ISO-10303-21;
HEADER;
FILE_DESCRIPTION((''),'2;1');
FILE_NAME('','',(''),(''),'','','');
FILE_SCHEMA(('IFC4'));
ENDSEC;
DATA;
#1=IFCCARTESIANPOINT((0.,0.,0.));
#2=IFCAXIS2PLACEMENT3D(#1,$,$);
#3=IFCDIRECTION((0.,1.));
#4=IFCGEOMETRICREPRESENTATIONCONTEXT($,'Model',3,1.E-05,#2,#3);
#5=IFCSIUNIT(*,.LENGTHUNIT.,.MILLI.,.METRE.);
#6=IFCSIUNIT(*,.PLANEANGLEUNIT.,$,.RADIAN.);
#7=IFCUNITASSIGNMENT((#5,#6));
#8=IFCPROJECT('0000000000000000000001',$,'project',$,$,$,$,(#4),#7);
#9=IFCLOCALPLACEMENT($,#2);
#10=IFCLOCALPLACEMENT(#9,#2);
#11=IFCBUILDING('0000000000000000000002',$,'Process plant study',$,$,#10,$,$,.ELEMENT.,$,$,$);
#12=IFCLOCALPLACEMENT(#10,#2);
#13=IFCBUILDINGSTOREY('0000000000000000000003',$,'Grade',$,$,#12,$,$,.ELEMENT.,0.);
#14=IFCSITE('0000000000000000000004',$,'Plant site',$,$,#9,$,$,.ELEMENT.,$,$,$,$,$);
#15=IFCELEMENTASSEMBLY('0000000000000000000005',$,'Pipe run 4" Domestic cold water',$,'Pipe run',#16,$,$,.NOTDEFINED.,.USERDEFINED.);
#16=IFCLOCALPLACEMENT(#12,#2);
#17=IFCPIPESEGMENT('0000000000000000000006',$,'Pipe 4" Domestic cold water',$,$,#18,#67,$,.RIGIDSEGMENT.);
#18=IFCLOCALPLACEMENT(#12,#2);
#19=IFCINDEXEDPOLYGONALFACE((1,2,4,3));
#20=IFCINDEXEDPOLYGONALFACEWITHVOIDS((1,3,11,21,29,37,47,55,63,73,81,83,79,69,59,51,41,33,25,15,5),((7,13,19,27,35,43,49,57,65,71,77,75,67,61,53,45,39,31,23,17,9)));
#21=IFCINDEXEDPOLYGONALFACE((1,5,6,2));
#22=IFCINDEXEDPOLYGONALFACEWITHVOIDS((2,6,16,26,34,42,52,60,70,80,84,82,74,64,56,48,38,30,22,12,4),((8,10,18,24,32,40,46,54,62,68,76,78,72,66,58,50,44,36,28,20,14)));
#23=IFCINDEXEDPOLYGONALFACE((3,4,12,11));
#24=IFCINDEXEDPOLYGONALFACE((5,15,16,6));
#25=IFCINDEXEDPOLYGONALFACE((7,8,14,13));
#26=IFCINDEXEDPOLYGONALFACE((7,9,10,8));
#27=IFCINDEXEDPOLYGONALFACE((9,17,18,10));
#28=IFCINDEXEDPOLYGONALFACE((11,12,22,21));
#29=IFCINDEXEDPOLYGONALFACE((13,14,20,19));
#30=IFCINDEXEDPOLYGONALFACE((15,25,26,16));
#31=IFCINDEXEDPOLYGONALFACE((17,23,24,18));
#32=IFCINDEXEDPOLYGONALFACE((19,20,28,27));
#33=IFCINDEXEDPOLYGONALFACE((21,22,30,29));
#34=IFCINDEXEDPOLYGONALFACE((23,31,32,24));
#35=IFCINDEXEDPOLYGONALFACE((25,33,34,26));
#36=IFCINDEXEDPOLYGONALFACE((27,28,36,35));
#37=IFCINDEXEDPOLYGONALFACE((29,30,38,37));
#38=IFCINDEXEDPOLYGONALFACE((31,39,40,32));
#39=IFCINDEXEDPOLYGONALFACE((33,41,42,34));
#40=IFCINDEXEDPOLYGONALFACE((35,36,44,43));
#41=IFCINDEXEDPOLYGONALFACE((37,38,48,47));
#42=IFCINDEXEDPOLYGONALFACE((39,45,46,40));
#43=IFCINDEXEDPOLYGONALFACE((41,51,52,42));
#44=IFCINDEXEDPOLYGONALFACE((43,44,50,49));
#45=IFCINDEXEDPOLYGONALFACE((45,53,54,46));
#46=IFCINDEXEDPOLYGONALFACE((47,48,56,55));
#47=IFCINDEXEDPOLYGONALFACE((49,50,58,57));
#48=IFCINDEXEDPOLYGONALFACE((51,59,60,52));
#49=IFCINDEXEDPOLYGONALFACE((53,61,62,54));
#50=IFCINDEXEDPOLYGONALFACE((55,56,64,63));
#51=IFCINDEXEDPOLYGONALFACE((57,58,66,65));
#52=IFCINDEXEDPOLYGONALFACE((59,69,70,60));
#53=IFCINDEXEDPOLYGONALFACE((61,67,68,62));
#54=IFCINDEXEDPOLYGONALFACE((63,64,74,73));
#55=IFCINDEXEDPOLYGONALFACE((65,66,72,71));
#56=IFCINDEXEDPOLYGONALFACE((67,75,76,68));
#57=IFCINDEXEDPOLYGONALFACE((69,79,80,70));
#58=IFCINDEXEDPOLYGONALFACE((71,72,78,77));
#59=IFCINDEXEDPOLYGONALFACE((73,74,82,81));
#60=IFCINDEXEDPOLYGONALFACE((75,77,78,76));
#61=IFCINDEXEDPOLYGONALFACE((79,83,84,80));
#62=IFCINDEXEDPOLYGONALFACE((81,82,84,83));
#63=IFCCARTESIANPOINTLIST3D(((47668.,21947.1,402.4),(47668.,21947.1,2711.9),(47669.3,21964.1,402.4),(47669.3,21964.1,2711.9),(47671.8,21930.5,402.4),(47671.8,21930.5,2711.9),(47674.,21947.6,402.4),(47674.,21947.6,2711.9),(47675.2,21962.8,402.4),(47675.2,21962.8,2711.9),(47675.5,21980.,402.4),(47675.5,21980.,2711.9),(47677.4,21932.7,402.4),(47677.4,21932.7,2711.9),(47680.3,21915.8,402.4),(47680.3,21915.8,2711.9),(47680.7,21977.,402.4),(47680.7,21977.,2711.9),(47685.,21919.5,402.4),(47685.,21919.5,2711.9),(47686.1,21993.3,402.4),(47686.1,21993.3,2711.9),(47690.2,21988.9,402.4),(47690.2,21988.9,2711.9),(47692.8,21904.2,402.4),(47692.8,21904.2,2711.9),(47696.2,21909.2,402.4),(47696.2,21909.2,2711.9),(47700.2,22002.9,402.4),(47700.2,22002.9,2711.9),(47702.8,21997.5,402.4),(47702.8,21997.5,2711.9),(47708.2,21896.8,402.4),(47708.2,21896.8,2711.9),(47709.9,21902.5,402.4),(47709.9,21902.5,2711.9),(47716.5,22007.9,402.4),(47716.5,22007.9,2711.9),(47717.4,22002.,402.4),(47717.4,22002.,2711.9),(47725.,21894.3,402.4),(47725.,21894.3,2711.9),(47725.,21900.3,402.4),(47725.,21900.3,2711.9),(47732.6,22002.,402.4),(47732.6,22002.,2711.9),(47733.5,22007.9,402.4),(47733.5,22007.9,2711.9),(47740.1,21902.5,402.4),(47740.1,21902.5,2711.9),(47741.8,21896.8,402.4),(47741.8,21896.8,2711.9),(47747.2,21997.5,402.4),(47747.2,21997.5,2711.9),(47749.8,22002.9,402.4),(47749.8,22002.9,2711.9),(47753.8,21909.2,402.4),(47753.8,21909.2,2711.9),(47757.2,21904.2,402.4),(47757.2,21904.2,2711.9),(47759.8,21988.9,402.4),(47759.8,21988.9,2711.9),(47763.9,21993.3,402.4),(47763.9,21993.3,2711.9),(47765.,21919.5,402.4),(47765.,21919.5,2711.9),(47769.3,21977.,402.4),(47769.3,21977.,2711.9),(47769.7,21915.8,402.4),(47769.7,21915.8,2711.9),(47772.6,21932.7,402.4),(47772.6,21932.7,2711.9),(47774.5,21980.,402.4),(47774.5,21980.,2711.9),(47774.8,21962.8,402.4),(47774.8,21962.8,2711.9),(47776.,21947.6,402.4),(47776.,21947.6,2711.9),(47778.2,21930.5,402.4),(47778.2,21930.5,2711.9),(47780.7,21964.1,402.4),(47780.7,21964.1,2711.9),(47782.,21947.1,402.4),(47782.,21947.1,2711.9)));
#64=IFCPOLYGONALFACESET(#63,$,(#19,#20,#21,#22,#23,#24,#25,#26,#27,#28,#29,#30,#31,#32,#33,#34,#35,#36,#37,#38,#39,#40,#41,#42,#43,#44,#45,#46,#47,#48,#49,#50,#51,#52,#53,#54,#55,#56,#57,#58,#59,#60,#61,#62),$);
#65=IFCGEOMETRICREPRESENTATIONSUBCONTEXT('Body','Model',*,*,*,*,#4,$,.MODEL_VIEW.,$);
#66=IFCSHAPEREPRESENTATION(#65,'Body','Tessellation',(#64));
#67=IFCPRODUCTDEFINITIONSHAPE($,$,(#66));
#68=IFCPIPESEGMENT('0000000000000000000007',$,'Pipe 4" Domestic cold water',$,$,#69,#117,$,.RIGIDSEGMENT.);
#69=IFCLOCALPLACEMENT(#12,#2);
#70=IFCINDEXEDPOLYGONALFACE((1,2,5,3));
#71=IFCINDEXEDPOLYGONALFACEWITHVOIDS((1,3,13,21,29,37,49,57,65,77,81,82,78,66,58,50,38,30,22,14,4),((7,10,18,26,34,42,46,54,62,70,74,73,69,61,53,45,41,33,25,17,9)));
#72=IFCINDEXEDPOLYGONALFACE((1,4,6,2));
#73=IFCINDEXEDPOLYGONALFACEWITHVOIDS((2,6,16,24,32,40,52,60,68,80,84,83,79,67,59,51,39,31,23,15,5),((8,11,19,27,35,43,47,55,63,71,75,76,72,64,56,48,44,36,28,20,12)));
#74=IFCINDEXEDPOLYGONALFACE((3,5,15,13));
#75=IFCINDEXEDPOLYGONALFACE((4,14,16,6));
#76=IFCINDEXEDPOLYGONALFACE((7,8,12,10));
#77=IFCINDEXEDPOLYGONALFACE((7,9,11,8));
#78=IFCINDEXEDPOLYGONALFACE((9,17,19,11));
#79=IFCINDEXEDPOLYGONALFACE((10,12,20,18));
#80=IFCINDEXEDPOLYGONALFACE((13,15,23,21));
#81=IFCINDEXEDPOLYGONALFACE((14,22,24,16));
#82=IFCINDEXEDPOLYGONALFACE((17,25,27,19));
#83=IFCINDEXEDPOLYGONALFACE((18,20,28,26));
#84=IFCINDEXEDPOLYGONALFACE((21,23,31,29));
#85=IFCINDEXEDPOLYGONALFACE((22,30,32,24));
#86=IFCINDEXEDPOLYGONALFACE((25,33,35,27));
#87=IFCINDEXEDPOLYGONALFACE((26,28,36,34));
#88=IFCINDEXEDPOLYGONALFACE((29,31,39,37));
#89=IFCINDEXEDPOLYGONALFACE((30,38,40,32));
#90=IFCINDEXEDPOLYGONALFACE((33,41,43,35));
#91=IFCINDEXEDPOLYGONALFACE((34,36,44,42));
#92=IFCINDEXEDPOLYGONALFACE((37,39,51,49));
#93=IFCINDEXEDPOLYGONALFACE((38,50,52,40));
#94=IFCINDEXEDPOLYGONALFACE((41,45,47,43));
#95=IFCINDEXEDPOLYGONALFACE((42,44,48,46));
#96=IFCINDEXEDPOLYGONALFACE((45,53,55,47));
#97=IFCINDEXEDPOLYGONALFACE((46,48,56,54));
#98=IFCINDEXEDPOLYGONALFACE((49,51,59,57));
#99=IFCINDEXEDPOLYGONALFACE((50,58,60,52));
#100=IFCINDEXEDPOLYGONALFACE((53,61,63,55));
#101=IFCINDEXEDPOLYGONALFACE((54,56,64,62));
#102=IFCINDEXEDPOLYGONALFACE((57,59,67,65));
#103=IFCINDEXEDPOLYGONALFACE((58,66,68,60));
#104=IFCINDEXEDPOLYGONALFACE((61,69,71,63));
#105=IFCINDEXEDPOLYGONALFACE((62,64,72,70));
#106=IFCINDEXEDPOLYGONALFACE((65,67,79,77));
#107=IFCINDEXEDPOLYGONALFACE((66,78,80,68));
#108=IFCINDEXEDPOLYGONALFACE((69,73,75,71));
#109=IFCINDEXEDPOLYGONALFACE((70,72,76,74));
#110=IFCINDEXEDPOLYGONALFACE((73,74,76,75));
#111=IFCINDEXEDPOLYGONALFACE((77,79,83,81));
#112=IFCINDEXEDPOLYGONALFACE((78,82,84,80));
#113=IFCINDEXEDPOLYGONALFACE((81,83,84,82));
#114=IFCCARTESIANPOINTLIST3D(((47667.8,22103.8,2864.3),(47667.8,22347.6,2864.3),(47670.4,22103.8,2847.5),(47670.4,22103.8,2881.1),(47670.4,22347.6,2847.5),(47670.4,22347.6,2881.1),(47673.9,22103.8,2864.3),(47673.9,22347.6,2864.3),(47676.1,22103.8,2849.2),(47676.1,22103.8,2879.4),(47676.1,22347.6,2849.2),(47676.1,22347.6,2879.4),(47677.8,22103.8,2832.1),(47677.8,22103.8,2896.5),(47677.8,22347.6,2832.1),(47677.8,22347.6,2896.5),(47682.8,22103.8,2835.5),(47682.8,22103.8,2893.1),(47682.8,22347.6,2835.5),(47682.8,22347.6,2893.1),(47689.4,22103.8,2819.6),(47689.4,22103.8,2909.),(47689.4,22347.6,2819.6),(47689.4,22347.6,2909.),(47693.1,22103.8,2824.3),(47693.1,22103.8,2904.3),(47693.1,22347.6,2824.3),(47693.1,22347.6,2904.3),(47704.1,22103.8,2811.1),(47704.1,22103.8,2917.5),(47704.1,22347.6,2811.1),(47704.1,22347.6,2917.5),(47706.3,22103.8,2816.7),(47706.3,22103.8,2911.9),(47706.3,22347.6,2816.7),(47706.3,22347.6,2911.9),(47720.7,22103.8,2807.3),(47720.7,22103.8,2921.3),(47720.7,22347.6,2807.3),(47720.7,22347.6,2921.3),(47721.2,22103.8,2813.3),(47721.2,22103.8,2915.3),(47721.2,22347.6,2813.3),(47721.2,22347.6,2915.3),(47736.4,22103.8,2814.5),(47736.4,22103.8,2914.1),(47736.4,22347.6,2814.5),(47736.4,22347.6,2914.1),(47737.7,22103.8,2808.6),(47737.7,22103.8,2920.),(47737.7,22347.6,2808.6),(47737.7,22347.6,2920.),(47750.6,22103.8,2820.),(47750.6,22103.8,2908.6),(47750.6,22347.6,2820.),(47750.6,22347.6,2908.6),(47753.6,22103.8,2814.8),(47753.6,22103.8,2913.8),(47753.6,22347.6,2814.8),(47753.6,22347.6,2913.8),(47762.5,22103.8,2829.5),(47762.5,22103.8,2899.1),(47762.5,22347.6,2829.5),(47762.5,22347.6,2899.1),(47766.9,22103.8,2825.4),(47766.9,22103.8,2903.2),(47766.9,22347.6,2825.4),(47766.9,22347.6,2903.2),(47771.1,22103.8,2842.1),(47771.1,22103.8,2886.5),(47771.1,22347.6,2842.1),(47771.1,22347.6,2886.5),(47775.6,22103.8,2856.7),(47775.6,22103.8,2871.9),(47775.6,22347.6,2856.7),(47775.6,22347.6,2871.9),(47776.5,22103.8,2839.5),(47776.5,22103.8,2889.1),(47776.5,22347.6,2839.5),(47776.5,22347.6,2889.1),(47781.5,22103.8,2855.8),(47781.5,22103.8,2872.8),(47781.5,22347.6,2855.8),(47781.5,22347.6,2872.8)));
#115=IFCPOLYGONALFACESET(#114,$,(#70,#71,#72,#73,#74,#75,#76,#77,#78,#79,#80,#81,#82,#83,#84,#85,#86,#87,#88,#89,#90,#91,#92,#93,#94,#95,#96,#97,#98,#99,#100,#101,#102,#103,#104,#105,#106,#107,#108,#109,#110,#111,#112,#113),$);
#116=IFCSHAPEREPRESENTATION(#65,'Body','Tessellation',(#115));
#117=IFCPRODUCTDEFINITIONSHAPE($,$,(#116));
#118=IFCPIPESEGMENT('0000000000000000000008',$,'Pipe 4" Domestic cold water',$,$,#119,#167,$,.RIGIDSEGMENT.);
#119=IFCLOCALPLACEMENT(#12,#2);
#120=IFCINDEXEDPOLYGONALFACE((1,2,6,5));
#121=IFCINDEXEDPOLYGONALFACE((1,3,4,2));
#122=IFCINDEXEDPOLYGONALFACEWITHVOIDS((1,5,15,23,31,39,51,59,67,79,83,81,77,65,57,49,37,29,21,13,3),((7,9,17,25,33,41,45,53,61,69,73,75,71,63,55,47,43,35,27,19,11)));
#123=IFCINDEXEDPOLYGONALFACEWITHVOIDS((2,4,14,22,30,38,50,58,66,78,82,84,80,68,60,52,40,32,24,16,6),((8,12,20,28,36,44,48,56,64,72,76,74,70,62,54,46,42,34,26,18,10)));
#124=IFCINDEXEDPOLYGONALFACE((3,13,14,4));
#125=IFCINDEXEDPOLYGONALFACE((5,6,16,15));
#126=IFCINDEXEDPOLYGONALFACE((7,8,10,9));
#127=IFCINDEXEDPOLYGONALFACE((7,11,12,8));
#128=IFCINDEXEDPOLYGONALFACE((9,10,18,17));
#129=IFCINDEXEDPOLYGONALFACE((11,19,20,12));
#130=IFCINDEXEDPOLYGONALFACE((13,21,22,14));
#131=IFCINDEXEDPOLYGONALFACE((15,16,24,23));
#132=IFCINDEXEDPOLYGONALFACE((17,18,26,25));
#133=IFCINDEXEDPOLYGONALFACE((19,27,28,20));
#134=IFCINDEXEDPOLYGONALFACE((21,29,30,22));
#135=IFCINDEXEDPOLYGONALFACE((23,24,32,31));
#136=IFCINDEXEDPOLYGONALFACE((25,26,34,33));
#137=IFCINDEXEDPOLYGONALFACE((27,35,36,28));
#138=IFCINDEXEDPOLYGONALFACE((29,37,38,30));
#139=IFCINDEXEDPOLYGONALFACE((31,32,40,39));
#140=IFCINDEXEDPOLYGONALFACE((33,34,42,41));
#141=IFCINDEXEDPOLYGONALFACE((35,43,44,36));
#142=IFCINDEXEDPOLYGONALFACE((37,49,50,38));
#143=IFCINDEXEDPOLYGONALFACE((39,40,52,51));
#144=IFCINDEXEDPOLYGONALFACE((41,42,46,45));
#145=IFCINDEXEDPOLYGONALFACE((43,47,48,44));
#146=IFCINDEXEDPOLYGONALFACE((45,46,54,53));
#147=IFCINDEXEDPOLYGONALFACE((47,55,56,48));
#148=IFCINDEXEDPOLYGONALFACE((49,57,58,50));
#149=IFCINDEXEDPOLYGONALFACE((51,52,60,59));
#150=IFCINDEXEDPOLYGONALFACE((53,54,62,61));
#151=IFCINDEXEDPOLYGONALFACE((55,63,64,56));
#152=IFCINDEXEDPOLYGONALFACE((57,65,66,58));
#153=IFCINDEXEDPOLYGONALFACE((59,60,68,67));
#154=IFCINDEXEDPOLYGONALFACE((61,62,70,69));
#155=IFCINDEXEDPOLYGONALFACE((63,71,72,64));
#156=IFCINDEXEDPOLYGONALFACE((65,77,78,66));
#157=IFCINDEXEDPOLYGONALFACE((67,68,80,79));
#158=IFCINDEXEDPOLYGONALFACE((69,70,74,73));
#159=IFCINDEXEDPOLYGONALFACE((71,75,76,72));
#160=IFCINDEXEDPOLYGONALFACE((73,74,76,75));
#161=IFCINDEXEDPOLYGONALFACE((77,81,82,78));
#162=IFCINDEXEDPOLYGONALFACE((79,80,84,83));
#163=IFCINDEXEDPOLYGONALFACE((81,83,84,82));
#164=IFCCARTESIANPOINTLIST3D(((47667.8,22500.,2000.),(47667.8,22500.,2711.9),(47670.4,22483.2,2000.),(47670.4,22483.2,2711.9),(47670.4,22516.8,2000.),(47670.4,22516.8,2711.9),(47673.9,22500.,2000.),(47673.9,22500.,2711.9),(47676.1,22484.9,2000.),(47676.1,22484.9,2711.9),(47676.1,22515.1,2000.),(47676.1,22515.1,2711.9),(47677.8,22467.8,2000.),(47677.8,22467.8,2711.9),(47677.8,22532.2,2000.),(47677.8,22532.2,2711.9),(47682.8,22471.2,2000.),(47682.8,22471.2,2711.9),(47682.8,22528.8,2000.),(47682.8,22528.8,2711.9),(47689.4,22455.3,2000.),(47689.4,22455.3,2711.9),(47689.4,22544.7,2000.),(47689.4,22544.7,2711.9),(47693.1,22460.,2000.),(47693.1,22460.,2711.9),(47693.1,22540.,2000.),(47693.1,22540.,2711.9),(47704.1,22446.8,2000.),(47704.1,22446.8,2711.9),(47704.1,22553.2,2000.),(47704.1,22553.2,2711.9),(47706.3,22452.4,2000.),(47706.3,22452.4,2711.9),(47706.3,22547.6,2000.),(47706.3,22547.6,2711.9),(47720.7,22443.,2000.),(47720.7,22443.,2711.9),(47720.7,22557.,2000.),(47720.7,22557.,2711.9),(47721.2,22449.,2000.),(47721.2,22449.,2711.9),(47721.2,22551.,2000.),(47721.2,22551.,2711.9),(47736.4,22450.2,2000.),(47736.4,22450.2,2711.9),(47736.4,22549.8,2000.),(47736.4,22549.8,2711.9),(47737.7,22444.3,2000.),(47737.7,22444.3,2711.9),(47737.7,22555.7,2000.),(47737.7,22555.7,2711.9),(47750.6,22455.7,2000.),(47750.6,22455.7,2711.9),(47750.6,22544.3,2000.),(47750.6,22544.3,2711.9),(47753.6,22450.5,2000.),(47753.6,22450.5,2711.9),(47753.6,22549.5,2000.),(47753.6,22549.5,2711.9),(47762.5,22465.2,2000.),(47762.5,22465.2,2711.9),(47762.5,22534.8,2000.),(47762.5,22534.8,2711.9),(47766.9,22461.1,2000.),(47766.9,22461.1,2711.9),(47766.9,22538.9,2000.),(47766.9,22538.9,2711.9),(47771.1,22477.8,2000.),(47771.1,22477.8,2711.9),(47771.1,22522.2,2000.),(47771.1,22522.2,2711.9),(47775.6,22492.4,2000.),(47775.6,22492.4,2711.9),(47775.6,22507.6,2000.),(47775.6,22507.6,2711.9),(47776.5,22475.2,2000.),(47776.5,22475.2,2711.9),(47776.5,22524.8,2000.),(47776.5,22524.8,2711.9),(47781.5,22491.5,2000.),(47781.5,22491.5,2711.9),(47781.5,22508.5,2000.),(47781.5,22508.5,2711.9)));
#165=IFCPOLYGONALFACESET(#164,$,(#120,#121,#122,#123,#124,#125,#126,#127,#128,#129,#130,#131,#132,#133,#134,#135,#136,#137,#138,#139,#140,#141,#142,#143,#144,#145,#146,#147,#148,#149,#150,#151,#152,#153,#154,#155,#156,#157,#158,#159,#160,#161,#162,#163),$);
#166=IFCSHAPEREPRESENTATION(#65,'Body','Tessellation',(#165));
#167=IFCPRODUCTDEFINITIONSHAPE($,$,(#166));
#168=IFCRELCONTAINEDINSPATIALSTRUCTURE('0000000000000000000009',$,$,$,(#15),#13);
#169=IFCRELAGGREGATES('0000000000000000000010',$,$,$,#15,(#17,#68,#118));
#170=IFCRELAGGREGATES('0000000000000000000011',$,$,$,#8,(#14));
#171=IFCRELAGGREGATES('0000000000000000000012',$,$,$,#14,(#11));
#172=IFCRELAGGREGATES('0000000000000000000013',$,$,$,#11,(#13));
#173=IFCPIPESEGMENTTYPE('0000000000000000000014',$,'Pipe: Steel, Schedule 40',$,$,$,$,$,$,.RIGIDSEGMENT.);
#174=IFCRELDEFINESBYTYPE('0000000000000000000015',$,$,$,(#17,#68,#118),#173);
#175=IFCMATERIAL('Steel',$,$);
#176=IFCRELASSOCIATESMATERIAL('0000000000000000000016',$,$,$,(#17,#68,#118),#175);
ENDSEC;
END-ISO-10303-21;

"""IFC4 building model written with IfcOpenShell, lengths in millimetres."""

from ifc_helpers import new_model, si_unit, direction, frame, origin, origin_with_axes, origin_2d, place, context, subcontext, project, spatial, hollow_circle, extrude, material, type_object, element, aggregate, save


model = new_model("IFC4")

# Units and contexts
model_context = context("Model", 3, precision=1e-05, world=origin(), true_north=direction((0.0, 1.0)))
body_context = subcontext(model_context, "Body", "Model", "MODEL_VIEW")
ifc_project = project(units=[si_unit("LENGTHUNIT", "METRE", prefix="MILLI"), si_unit("PLANEANGLEUNIT", "RADIAN")], contexts=[model_context])

# Site, building, storey
site_placement = place(None, origin())
site = spatial("IfcSite", under=ifc_project, at=site_placement, Name="Plant site", CompositionType="ELEMENT")
building_placement = place(site_placement, origin())
building = spatial("IfcBuilding", under=site, at=building_placement, Name="Process plant study", CompositionType="ELEMENT")
storey_placement = place(building_placement, origin())
storey = spatial("IfcBuildingStorey", under=building, at=storey_placement, Name="Grade", CompositionType="ELEMENT", Elevation=0.0)

# Element assembly, pipe segments
assembly_1_placement = place(storey_placement, origin_with_axes())
assembly_1 = element("IfcElementAssembly", 1, at=assembly_1_placement, inside=storey, Name="Pipe run 4\" Domestic cold water", ObjectType="Pipe run", AssemblyPlace="NOTDEFINED", PredefinedType="USERDEFINED")
ifc_material = material(Name="Steel")
pipe_segment_type = type_object("IfcPipeSegmentType", Name="Pipe: Steel, Schedule 40", PredefinedType="RIGIDSEGMENT")
pipe_segment_1_placement = place(storey_placement, origin_with_axes())
pipe_segment_1 = element("IfcPipeSegment", 2, at=pipe_segment_1_placement, type_object=pipe_segment_type, material=ifc_material, Name="Pipe 4\" Domestic cold water", PredefinedType="RIGIDSEGMENT", context=body_context, shape_type="SweptSolid", body=[
    extrude(hollow_circle(Radius=57.1, WallThickness=6.0, at=origin_2d()), frame((47725.0, 21951.4, 402.4), z_axis=(0.0, 0.0, 1.0), x_axis=(0.0, -1.0, 0.0)), (0.0, 0.0, 1.0), 2309.5),
])
pipe_segment_2_placement = place(storey_placement, origin_with_axes())
pipe_segment_2 = element("IfcPipeSegment", 3, at=pipe_segment_2_placement, type_object=pipe_segment_type, material=ifc_material, Name="Pipe 4\" Domestic cold water", PredefinedType="RIGIDSEGMENT", context=body_context, shape_type="SweptSolid", body=[
    extrude(hollow_circle(Radius=57.1, WallThickness=6.0, at=origin_2d()), frame((47725.0, 22103.8, 2864.3), z_axis=(0.0, 1.0, 0.0), x_axis=(-1.0, 0.0, 0.0)), (0.0, 0.0, 1.0), 243.8),
])
pipe_segment_3_placement = place(storey_placement, origin_with_axes())
pipe_segment_3 = element("IfcPipeSegment", 4, at=pipe_segment_3_placement, type_object=pipe_segment_type, material=ifc_material, Name="Pipe 4\" Domestic cold water", PredefinedType="RIGIDSEGMENT", context=body_context, shape_type="SweptSolid", body=[
    extrude(hollow_circle(Radius=57.1, WallThickness=6.0, at=origin_2d()), frame((47725.0, 22500.0, 2711.9), z_axis=(0.0, 0.0, -1.0), x_axis=(-1.0, 0.0, 0.0)), (0.0, 0.0, 1.0), 711.9),
])

aggregate(assembly_1, [pipe_segment_1, pipe_segment_2, pipe_segment_3])

save(model, "model.ifc")
